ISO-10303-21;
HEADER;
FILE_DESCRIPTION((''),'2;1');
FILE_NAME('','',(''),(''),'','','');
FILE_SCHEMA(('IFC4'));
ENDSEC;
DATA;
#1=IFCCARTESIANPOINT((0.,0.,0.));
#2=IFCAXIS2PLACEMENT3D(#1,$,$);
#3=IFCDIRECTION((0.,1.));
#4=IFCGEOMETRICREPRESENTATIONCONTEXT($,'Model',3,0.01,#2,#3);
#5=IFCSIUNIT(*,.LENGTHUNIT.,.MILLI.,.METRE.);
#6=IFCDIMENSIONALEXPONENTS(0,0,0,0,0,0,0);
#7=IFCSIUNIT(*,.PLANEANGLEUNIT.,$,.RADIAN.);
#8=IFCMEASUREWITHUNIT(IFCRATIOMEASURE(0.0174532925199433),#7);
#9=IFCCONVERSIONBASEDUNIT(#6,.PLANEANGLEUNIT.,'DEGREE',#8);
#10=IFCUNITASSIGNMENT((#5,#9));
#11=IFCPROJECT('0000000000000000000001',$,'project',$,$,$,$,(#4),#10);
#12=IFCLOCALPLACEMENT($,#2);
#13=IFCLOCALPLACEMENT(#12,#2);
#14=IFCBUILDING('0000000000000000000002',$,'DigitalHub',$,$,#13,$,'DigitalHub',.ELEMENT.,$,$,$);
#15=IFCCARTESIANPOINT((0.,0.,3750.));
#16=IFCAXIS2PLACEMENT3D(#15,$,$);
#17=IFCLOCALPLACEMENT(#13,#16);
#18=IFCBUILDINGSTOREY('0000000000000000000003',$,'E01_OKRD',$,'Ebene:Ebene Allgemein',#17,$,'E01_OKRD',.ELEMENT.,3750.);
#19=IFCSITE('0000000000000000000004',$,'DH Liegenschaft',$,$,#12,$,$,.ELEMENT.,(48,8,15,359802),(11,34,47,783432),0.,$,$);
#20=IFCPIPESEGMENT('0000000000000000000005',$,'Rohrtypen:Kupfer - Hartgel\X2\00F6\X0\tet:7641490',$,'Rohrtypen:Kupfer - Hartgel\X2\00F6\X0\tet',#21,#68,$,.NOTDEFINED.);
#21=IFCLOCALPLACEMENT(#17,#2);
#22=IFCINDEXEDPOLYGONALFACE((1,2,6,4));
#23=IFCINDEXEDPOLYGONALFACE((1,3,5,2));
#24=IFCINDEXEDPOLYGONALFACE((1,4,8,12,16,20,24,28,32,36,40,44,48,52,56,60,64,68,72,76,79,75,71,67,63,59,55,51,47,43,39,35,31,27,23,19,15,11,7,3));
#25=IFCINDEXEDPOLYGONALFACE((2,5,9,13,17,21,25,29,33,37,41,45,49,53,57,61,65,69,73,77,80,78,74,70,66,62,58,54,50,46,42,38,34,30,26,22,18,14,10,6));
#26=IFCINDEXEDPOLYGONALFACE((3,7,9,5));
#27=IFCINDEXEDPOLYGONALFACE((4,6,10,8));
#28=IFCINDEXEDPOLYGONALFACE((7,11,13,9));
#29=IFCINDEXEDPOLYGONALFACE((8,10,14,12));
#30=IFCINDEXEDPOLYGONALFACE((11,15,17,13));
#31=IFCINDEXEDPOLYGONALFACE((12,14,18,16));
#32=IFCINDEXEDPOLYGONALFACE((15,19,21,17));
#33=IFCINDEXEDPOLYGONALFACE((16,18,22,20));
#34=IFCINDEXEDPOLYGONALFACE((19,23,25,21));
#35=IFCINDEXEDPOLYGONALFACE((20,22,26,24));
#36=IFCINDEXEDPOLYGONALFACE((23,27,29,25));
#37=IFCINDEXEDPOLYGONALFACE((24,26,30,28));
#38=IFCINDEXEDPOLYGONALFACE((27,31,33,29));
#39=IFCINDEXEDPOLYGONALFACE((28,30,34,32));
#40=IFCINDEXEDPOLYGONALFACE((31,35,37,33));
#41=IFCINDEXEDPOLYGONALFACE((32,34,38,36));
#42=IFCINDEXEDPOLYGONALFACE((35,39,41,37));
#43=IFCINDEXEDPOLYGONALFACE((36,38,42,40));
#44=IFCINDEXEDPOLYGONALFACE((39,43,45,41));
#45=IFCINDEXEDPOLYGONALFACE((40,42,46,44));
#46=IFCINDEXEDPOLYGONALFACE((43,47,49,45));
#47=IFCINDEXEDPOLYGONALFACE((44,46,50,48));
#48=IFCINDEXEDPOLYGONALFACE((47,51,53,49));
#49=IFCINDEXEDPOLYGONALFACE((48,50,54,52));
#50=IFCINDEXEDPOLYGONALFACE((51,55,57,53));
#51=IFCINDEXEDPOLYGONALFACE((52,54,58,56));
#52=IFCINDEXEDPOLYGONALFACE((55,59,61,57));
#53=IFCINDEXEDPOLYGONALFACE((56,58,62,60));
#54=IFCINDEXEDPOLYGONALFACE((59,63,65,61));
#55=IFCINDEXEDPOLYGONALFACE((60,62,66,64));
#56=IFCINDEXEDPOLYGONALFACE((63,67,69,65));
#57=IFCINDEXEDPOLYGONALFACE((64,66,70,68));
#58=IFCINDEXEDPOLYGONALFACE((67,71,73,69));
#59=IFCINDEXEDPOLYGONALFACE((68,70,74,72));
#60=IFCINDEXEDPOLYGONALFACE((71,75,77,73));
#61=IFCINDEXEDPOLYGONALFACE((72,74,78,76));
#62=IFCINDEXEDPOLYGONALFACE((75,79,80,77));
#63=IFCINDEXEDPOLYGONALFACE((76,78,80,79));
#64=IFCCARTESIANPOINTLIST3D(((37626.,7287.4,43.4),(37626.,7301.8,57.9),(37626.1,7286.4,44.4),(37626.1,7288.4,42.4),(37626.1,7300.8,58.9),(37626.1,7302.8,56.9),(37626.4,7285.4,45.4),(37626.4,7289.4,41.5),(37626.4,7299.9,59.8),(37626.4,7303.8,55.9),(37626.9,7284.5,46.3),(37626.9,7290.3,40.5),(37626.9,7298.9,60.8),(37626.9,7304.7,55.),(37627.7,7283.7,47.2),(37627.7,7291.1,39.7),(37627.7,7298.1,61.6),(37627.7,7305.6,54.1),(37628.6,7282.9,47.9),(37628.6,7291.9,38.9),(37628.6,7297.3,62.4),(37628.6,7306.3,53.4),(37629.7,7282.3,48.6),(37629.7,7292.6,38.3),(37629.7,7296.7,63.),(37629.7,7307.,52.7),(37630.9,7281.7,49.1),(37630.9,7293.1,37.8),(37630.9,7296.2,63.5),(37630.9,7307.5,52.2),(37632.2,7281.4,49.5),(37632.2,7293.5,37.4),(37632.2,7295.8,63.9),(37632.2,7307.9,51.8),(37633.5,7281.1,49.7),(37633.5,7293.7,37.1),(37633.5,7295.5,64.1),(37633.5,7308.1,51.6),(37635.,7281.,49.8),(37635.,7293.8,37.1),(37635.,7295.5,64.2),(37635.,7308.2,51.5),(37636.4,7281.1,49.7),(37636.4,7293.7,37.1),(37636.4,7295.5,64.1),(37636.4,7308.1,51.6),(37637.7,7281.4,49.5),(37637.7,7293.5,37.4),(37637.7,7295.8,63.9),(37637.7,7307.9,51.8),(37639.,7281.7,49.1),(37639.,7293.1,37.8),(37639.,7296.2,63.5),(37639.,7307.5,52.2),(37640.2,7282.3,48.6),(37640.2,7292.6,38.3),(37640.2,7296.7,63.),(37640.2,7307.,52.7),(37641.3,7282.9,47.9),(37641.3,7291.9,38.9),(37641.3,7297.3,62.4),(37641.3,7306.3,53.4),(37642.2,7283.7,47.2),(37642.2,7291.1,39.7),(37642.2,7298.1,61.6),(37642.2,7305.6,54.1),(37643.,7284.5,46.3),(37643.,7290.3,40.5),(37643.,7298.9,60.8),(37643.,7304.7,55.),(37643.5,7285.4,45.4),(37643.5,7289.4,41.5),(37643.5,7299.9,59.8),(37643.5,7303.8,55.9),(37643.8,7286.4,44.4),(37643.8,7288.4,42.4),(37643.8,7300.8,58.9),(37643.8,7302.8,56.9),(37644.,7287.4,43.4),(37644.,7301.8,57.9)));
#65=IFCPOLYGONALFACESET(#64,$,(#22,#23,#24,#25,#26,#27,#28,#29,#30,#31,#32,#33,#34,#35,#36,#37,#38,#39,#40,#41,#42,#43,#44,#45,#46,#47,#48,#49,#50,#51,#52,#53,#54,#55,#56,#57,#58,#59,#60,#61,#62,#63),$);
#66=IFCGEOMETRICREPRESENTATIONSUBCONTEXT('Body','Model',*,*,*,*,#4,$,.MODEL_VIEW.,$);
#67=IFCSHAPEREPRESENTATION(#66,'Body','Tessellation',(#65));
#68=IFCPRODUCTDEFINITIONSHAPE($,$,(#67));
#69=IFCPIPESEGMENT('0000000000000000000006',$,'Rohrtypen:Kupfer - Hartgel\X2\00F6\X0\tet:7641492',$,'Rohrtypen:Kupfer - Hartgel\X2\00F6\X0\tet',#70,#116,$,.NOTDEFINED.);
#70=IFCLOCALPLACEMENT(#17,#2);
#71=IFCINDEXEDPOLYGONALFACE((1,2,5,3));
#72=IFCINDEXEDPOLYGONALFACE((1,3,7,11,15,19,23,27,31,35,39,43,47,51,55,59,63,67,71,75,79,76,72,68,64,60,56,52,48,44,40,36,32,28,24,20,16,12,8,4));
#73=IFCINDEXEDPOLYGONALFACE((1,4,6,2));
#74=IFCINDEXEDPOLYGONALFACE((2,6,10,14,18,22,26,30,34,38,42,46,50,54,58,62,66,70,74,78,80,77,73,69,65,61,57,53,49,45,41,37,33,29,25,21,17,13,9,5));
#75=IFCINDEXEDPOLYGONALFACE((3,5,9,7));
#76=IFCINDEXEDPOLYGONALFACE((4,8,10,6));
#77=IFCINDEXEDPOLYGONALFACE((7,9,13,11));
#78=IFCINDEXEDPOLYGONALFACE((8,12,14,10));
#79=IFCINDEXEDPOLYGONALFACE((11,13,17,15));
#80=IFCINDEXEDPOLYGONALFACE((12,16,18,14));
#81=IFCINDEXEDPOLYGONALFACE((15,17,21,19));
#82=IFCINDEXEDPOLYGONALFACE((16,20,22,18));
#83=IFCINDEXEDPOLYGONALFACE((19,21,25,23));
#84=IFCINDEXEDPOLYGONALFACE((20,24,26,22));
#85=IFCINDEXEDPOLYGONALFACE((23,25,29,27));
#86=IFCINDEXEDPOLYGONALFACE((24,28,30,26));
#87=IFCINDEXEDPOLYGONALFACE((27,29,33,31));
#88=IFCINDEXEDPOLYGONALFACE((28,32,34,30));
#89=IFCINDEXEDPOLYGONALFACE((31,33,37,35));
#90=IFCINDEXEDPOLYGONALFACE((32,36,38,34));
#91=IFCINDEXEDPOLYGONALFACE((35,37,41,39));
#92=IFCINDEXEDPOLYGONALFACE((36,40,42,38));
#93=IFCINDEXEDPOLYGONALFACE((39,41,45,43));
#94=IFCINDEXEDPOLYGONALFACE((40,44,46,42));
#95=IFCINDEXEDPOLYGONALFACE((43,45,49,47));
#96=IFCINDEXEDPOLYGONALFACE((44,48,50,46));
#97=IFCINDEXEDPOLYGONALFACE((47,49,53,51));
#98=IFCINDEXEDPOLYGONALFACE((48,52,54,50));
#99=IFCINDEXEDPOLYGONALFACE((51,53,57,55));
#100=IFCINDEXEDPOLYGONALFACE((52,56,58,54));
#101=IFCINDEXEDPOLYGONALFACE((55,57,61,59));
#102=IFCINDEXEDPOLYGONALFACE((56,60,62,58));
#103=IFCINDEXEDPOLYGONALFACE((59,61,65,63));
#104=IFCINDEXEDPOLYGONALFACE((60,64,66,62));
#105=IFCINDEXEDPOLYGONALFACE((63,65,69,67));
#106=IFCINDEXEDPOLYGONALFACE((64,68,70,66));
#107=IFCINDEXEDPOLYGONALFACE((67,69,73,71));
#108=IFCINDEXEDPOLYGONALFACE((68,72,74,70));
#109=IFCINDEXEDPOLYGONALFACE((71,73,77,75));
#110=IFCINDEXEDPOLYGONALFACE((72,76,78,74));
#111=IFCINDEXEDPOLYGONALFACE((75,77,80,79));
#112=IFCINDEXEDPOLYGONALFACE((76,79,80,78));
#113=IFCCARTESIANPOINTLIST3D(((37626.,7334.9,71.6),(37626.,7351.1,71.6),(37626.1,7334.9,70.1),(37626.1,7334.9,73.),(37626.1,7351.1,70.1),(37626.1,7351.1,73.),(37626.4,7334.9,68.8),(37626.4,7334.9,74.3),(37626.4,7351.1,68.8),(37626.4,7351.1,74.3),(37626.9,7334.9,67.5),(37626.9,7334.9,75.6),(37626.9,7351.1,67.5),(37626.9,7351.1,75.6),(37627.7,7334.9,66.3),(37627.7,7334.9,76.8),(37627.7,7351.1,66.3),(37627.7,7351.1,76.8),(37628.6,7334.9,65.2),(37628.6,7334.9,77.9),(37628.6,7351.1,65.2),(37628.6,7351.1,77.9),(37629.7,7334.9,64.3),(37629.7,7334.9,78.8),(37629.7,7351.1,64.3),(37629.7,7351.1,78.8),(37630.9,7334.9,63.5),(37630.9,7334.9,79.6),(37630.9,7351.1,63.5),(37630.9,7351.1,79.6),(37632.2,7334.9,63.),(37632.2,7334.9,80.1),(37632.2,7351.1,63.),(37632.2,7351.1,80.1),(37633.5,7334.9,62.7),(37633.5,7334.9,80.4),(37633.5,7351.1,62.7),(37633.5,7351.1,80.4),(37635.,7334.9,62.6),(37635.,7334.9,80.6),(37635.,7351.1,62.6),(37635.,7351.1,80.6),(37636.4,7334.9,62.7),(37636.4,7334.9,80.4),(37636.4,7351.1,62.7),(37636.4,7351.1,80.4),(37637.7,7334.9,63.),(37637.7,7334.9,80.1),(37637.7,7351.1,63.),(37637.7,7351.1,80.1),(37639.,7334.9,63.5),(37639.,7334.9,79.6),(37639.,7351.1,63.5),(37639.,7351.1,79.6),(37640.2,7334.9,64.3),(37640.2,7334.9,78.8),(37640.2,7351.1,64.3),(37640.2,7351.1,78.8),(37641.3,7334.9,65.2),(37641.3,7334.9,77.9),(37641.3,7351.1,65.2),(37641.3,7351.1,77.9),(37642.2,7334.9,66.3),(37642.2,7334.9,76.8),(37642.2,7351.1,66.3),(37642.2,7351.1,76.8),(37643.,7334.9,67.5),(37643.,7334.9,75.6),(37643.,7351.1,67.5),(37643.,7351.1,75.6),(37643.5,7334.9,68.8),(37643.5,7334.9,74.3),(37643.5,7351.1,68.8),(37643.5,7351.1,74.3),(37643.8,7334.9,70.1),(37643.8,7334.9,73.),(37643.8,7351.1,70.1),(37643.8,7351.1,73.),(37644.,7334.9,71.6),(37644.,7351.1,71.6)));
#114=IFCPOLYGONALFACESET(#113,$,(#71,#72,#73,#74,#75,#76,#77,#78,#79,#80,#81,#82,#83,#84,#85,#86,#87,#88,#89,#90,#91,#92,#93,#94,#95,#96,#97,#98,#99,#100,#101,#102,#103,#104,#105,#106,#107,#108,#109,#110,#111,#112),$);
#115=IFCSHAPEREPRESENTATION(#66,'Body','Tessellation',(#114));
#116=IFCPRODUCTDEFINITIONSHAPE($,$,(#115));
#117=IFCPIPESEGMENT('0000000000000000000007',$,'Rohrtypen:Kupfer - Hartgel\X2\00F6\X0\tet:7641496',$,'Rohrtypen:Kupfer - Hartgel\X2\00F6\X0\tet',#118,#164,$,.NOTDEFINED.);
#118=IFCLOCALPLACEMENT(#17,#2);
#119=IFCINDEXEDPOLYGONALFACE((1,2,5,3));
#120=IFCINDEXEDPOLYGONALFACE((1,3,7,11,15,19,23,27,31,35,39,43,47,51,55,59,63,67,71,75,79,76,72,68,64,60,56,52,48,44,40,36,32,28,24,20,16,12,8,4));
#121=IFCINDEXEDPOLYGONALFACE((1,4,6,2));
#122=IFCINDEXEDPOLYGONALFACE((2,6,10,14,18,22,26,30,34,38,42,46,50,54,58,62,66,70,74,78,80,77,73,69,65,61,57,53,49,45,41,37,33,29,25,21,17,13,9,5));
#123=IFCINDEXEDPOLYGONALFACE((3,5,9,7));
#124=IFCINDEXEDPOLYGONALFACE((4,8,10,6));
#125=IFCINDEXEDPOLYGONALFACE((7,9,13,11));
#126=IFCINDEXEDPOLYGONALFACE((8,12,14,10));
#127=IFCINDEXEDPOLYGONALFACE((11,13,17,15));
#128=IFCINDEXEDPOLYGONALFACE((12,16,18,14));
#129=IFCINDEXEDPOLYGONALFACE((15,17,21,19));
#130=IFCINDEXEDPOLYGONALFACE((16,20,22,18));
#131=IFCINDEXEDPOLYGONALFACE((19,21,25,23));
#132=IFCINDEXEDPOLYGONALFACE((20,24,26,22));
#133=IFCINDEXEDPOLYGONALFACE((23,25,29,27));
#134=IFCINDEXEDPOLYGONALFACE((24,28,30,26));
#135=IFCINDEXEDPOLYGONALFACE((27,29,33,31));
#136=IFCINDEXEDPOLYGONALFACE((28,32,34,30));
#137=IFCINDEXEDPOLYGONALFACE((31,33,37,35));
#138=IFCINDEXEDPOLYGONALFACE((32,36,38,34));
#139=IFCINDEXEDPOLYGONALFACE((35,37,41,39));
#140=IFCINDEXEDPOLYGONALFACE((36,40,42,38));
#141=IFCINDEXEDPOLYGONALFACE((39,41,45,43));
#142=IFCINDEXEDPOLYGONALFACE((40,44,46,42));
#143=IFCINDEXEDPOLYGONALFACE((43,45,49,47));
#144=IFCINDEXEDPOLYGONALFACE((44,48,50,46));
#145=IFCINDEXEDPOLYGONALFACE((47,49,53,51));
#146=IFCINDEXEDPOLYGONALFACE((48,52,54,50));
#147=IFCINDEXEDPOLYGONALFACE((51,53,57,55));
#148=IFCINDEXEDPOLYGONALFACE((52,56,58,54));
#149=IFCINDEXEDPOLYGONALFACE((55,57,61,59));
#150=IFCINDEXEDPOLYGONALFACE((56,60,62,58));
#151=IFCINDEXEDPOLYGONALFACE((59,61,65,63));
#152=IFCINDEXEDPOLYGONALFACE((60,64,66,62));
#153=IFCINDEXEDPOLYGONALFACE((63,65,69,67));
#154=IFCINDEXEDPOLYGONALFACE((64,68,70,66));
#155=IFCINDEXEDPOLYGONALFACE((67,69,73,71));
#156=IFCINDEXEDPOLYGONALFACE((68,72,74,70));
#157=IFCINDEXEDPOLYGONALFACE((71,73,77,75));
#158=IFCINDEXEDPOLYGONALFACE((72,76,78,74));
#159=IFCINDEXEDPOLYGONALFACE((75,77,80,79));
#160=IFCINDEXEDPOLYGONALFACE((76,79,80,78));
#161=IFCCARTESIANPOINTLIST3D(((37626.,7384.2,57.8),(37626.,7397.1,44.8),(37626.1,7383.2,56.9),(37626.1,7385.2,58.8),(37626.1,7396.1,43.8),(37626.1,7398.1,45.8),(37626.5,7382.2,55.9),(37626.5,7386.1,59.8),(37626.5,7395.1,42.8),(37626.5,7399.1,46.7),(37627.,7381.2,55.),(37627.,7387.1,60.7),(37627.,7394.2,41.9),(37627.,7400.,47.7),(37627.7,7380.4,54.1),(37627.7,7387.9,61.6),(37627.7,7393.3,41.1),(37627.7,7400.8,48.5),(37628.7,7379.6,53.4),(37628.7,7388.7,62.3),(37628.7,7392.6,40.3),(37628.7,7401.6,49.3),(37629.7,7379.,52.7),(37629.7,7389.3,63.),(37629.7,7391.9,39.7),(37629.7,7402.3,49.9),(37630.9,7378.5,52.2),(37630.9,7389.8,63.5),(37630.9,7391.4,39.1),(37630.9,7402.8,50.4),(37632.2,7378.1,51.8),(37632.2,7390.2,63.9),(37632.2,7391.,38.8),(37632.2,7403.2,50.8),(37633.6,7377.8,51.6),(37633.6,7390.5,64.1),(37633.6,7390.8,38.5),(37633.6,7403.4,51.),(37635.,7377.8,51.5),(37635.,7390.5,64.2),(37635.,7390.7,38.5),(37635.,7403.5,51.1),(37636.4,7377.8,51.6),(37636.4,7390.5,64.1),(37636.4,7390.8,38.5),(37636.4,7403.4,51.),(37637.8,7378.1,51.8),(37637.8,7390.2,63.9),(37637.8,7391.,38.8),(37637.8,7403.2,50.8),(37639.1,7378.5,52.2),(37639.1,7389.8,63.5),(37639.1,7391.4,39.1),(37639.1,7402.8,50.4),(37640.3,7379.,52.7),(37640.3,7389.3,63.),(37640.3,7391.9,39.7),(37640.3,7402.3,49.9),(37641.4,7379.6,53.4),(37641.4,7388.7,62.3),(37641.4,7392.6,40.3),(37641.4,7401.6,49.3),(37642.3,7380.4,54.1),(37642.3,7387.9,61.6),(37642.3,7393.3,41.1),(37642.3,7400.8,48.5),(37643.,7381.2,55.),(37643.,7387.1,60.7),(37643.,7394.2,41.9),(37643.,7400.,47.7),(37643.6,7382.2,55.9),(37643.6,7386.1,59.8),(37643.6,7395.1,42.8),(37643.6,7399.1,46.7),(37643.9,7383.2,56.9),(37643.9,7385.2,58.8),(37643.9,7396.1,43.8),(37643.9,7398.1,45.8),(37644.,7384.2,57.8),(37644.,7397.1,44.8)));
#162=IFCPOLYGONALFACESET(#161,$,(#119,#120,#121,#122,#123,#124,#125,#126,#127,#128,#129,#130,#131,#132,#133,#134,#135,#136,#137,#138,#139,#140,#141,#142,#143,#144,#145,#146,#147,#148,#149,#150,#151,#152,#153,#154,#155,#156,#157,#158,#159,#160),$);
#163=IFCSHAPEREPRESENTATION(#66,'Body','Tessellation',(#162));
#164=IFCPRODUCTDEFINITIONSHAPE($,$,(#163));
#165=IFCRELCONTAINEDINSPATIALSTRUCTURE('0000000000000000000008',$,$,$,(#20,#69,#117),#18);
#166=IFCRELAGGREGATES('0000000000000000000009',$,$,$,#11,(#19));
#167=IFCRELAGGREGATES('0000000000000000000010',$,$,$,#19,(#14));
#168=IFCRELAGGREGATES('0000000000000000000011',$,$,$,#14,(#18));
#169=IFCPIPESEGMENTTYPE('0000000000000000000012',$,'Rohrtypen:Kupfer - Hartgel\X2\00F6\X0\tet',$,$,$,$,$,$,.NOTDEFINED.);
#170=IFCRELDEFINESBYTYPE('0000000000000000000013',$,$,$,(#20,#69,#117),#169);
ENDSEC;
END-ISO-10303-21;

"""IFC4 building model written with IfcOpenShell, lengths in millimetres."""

from ifc_helpers import new_model, entity, si_unit, converted_unit, direction, frame, origin, place, context, subcontext, project, spatial, indexed_curve, outline, extrude, type_object, element, save


model = new_model("IFC4")

# Units and contexts
model_context = context("Model", 3, precision=0.01, world=origin(), true_north=direction((0.0, 1.0)))
body_context = subcontext(model_context, "Body", "Model", "MODEL_VIEW")
ifc_project = project(units=[si_unit("LENGTHUNIT", "METRE", prefix="MILLI"), converted_unit("PLANEANGLEUNIT", "DEGREE", entity("IfcRatioMeasure", 0.0174532925199433), si_unit("PLANEANGLEUNIT", "RADIAN"), dimensions=[0, 0, 0, 0, 0, 0, 0])], contexts=[model_context])

# Site, building, storey
site_placement = place(None, origin())
site = spatial("IfcSite", under=ifc_project, at=site_placement, Name="DH Liegenschaft", CompositionType="ELEMENT", RefLatitude=(48, 8, 15, 359802), RefLongitude=(11, 34, 47, 783432), RefElevation=0.0)
building_placement = place(site_placement, origin())
building = spatial("IfcBuilding", under=site, at=building_placement, Name="DigitalHub", LongName="DigitalHub", CompositionType="ELEMENT")
storey_placement = place(building_placement, frame((0.0, 0.0, 3750.0)))
storey = spatial("IfcBuildingStorey", under=building, at=storey_placement, Name="E01_OKRD", ObjectType="Ebene:Ebene Allgemein", LongName="E01_OKRD", CompositionType="ELEMENT", Elevation=3750.0)

# Pipe segments
pipe_segment_type = type_object("IfcPipeSegmentType", Name="Rohrtypen:Kupfer - Hartgelötet", PredefinedType="NOTDEFINED")
pipe_segment_1_placement = place(storey_placement, frame((37624.4, 7279.4, 35.5)))
element("IfcPipeSegment", 1, at=pipe_segment_1_placement, inside=storey, type_object=pipe_segment_type, Name="Rohrtypen:Kupfer - Hartgelötet:7641490", ObjectType="Rohrtypen:Kupfer - Hartgelötet", PredefinedType="NOTDEFINED", context=body_context, shape_type="SweptSolid", body=[
    extrude(outline(indexed_curve([(9.0, 0.0), (8.9, 1.4), (8.6, 2.8), (8.0, 4.1), (7.3, 5.3), (6.4, 6.4), (5.3, 7.3), (4.1, 8.0), (2.8, 8.6), (1.4, 8.9), (0.0, 9.0), (-1.4, 8.9), (-2.8, 8.6), (-4.1, 8.0), (-5.3, 7.3), (-6.4, 6.4), (-7.3, 5.3), (-8.0, 4.1), (-8.6, 2.8), (-8.9, 1.4), (-9.0, 0.0), (-8.9, -1.4), (-8.6, -2.8), (-8.0, -4.1), (-7.3, -5.3), (-6.4, -6.4), (-5.3, -7.3), (-4.1, -8.0), (-2.8, -8.6), (-1.4, -8.9), (0.0, -9.0), (1.4, -8.9), (2.8, -8.6), (4.1, -8.0), (5.3, -7.3), (6.4, -6.4), (7.3, -5.3), (8.0, -4.1), (8.6, -2.8), (8.9, -1.4), (9.0, 0.0)], self_intersect=False)), frame((10.6, 8.0, 8.0), z_axis=(0.0, 0.707107, 0.707107), x_axis=(1.0, 0.0, 0.0)), (0.0, 0.0, 1.0), 20.4),
])
pipe_segment_2_placement = place(storey_placement, frame((37624.4, 7334.9, 61.0)))
element("IfcPipeSegment", 2, at=pipe_segment_2_placement, inside=storey, type_object=pipe_segment_type, Name="Rohrtypen:Kupfer - Hartgelötet:7641492", ObjectType="Rohrtypen:Kupfer - Hartgelötet", PredefinedType="NOTDEFINED", context=body_context, shape_type="SweptSolid", body=[
    extrude(outline(indexed_curve([(9.0, 0.0), (8.9, 1.4), (8.6, 2.8), (8.0, 4.1), (7.3, 5.3), (6.4, 6.4), (5.3, 7.3), (4.1, 8.0), (2.8, 8.6), (1.4, 8.9), (0.0, 9.0), (-1.4, 8.9), (-2.8, 8.6), (-4.1, 8.0), (-5.3, 7.3), (-6.4, 6.4), (-7.3, 5.3), (-8.0, 4.1), (-8.6, 2.8), (-8.9, 1.4), (-9.0, 0.0), (-8.9, -1.4), (-8.6, -2.8), (-8.0, -4.1), (-7.3, -5.3), (-6.4, -6.4), (-5.3, -7.3), (-4.1, -8.0), (-2.8, -8.6), (-1.4, -8.9), (0.0, -9.0), (1.4, -8.9), (2.8, -8.6), (4.1, -8.0), (5.3, -7.3), (6.4, -6.4), (7.3, -5.3), (8.0, -4.1), (8.6, -2.8), (8.9, -1.4), (9.0, 0.0)], self_intersect=False)), frame((10.6, 16.2, 10.6), z_axis=(0.0, -1.0, 0.000282), x_axis=(-1.0, 0.0, 0.0)), (0.0, 0.0, 1.0), 16.2),
])
pipe_segment_3_placement = place(storey_placement, frame((37624.4, 7376.2, 36.9)))
element("IfcPipeSegment", 3, at=pipe_segment_3_placement, inside=storey, type_object=pipe_segment_type, Name="Rohrtypen:Kupfer - Hartgelötet:7641496", ObjectType="Rohrtypen:Kupfer - Hartgelötet", PredefinedType="NOTDEFINED", context=body_context, shape_type="SweptSolid", body=[
    extrude(outline(indexed_curve([(9.0, 0.0), (8.9, 1.4), (8.6, 2.8), (8.0, 4.1), (7.3, 5.3), (6.4, 6.4), (5.3, 7.3), (4.1, 8.0), (2.8, 8.6), (1.4, 8.9), (0.0, 9.0), (-1.4, 8.9), (-2.8, 8.6), (-4.1, 8.0), (-5.3, 7.3), (-6.4, 6.4), (-7.3, 5.3), (-8.0, 4.1), (-8.6, 2.8), (-8.9, 1.4), (-9.0, 0.0), (-8.9, -1.4), (-8.6, -2.8), (-8.0, -4.1), (-7.3, -5.3), (-6.4, -6.4), (-5.3, -7.3), (-4.1, -8.0), (-2.8, -8.6), (-1.4, -8.9), (0.0, -9.0), (1.4, -8.9), (2.8, -8.6), (4.1, -8.0), (5.3, -7.3), (6.4, -6.4), (7.3, -5.3), (8.0, -4.1), (8.6, -2.8), (8.9, -1.4), (9.0, 0.0)], self_intersect=False)), frame((10.6, 20.9, 7.9), z_axis=(0.0, -0.70394, 0.71026), x_axis=(-1.0, 0.0, 0.0)), (0.0, 0.0, 1.0), 18.4),
])

save(model, "model.ifc")
